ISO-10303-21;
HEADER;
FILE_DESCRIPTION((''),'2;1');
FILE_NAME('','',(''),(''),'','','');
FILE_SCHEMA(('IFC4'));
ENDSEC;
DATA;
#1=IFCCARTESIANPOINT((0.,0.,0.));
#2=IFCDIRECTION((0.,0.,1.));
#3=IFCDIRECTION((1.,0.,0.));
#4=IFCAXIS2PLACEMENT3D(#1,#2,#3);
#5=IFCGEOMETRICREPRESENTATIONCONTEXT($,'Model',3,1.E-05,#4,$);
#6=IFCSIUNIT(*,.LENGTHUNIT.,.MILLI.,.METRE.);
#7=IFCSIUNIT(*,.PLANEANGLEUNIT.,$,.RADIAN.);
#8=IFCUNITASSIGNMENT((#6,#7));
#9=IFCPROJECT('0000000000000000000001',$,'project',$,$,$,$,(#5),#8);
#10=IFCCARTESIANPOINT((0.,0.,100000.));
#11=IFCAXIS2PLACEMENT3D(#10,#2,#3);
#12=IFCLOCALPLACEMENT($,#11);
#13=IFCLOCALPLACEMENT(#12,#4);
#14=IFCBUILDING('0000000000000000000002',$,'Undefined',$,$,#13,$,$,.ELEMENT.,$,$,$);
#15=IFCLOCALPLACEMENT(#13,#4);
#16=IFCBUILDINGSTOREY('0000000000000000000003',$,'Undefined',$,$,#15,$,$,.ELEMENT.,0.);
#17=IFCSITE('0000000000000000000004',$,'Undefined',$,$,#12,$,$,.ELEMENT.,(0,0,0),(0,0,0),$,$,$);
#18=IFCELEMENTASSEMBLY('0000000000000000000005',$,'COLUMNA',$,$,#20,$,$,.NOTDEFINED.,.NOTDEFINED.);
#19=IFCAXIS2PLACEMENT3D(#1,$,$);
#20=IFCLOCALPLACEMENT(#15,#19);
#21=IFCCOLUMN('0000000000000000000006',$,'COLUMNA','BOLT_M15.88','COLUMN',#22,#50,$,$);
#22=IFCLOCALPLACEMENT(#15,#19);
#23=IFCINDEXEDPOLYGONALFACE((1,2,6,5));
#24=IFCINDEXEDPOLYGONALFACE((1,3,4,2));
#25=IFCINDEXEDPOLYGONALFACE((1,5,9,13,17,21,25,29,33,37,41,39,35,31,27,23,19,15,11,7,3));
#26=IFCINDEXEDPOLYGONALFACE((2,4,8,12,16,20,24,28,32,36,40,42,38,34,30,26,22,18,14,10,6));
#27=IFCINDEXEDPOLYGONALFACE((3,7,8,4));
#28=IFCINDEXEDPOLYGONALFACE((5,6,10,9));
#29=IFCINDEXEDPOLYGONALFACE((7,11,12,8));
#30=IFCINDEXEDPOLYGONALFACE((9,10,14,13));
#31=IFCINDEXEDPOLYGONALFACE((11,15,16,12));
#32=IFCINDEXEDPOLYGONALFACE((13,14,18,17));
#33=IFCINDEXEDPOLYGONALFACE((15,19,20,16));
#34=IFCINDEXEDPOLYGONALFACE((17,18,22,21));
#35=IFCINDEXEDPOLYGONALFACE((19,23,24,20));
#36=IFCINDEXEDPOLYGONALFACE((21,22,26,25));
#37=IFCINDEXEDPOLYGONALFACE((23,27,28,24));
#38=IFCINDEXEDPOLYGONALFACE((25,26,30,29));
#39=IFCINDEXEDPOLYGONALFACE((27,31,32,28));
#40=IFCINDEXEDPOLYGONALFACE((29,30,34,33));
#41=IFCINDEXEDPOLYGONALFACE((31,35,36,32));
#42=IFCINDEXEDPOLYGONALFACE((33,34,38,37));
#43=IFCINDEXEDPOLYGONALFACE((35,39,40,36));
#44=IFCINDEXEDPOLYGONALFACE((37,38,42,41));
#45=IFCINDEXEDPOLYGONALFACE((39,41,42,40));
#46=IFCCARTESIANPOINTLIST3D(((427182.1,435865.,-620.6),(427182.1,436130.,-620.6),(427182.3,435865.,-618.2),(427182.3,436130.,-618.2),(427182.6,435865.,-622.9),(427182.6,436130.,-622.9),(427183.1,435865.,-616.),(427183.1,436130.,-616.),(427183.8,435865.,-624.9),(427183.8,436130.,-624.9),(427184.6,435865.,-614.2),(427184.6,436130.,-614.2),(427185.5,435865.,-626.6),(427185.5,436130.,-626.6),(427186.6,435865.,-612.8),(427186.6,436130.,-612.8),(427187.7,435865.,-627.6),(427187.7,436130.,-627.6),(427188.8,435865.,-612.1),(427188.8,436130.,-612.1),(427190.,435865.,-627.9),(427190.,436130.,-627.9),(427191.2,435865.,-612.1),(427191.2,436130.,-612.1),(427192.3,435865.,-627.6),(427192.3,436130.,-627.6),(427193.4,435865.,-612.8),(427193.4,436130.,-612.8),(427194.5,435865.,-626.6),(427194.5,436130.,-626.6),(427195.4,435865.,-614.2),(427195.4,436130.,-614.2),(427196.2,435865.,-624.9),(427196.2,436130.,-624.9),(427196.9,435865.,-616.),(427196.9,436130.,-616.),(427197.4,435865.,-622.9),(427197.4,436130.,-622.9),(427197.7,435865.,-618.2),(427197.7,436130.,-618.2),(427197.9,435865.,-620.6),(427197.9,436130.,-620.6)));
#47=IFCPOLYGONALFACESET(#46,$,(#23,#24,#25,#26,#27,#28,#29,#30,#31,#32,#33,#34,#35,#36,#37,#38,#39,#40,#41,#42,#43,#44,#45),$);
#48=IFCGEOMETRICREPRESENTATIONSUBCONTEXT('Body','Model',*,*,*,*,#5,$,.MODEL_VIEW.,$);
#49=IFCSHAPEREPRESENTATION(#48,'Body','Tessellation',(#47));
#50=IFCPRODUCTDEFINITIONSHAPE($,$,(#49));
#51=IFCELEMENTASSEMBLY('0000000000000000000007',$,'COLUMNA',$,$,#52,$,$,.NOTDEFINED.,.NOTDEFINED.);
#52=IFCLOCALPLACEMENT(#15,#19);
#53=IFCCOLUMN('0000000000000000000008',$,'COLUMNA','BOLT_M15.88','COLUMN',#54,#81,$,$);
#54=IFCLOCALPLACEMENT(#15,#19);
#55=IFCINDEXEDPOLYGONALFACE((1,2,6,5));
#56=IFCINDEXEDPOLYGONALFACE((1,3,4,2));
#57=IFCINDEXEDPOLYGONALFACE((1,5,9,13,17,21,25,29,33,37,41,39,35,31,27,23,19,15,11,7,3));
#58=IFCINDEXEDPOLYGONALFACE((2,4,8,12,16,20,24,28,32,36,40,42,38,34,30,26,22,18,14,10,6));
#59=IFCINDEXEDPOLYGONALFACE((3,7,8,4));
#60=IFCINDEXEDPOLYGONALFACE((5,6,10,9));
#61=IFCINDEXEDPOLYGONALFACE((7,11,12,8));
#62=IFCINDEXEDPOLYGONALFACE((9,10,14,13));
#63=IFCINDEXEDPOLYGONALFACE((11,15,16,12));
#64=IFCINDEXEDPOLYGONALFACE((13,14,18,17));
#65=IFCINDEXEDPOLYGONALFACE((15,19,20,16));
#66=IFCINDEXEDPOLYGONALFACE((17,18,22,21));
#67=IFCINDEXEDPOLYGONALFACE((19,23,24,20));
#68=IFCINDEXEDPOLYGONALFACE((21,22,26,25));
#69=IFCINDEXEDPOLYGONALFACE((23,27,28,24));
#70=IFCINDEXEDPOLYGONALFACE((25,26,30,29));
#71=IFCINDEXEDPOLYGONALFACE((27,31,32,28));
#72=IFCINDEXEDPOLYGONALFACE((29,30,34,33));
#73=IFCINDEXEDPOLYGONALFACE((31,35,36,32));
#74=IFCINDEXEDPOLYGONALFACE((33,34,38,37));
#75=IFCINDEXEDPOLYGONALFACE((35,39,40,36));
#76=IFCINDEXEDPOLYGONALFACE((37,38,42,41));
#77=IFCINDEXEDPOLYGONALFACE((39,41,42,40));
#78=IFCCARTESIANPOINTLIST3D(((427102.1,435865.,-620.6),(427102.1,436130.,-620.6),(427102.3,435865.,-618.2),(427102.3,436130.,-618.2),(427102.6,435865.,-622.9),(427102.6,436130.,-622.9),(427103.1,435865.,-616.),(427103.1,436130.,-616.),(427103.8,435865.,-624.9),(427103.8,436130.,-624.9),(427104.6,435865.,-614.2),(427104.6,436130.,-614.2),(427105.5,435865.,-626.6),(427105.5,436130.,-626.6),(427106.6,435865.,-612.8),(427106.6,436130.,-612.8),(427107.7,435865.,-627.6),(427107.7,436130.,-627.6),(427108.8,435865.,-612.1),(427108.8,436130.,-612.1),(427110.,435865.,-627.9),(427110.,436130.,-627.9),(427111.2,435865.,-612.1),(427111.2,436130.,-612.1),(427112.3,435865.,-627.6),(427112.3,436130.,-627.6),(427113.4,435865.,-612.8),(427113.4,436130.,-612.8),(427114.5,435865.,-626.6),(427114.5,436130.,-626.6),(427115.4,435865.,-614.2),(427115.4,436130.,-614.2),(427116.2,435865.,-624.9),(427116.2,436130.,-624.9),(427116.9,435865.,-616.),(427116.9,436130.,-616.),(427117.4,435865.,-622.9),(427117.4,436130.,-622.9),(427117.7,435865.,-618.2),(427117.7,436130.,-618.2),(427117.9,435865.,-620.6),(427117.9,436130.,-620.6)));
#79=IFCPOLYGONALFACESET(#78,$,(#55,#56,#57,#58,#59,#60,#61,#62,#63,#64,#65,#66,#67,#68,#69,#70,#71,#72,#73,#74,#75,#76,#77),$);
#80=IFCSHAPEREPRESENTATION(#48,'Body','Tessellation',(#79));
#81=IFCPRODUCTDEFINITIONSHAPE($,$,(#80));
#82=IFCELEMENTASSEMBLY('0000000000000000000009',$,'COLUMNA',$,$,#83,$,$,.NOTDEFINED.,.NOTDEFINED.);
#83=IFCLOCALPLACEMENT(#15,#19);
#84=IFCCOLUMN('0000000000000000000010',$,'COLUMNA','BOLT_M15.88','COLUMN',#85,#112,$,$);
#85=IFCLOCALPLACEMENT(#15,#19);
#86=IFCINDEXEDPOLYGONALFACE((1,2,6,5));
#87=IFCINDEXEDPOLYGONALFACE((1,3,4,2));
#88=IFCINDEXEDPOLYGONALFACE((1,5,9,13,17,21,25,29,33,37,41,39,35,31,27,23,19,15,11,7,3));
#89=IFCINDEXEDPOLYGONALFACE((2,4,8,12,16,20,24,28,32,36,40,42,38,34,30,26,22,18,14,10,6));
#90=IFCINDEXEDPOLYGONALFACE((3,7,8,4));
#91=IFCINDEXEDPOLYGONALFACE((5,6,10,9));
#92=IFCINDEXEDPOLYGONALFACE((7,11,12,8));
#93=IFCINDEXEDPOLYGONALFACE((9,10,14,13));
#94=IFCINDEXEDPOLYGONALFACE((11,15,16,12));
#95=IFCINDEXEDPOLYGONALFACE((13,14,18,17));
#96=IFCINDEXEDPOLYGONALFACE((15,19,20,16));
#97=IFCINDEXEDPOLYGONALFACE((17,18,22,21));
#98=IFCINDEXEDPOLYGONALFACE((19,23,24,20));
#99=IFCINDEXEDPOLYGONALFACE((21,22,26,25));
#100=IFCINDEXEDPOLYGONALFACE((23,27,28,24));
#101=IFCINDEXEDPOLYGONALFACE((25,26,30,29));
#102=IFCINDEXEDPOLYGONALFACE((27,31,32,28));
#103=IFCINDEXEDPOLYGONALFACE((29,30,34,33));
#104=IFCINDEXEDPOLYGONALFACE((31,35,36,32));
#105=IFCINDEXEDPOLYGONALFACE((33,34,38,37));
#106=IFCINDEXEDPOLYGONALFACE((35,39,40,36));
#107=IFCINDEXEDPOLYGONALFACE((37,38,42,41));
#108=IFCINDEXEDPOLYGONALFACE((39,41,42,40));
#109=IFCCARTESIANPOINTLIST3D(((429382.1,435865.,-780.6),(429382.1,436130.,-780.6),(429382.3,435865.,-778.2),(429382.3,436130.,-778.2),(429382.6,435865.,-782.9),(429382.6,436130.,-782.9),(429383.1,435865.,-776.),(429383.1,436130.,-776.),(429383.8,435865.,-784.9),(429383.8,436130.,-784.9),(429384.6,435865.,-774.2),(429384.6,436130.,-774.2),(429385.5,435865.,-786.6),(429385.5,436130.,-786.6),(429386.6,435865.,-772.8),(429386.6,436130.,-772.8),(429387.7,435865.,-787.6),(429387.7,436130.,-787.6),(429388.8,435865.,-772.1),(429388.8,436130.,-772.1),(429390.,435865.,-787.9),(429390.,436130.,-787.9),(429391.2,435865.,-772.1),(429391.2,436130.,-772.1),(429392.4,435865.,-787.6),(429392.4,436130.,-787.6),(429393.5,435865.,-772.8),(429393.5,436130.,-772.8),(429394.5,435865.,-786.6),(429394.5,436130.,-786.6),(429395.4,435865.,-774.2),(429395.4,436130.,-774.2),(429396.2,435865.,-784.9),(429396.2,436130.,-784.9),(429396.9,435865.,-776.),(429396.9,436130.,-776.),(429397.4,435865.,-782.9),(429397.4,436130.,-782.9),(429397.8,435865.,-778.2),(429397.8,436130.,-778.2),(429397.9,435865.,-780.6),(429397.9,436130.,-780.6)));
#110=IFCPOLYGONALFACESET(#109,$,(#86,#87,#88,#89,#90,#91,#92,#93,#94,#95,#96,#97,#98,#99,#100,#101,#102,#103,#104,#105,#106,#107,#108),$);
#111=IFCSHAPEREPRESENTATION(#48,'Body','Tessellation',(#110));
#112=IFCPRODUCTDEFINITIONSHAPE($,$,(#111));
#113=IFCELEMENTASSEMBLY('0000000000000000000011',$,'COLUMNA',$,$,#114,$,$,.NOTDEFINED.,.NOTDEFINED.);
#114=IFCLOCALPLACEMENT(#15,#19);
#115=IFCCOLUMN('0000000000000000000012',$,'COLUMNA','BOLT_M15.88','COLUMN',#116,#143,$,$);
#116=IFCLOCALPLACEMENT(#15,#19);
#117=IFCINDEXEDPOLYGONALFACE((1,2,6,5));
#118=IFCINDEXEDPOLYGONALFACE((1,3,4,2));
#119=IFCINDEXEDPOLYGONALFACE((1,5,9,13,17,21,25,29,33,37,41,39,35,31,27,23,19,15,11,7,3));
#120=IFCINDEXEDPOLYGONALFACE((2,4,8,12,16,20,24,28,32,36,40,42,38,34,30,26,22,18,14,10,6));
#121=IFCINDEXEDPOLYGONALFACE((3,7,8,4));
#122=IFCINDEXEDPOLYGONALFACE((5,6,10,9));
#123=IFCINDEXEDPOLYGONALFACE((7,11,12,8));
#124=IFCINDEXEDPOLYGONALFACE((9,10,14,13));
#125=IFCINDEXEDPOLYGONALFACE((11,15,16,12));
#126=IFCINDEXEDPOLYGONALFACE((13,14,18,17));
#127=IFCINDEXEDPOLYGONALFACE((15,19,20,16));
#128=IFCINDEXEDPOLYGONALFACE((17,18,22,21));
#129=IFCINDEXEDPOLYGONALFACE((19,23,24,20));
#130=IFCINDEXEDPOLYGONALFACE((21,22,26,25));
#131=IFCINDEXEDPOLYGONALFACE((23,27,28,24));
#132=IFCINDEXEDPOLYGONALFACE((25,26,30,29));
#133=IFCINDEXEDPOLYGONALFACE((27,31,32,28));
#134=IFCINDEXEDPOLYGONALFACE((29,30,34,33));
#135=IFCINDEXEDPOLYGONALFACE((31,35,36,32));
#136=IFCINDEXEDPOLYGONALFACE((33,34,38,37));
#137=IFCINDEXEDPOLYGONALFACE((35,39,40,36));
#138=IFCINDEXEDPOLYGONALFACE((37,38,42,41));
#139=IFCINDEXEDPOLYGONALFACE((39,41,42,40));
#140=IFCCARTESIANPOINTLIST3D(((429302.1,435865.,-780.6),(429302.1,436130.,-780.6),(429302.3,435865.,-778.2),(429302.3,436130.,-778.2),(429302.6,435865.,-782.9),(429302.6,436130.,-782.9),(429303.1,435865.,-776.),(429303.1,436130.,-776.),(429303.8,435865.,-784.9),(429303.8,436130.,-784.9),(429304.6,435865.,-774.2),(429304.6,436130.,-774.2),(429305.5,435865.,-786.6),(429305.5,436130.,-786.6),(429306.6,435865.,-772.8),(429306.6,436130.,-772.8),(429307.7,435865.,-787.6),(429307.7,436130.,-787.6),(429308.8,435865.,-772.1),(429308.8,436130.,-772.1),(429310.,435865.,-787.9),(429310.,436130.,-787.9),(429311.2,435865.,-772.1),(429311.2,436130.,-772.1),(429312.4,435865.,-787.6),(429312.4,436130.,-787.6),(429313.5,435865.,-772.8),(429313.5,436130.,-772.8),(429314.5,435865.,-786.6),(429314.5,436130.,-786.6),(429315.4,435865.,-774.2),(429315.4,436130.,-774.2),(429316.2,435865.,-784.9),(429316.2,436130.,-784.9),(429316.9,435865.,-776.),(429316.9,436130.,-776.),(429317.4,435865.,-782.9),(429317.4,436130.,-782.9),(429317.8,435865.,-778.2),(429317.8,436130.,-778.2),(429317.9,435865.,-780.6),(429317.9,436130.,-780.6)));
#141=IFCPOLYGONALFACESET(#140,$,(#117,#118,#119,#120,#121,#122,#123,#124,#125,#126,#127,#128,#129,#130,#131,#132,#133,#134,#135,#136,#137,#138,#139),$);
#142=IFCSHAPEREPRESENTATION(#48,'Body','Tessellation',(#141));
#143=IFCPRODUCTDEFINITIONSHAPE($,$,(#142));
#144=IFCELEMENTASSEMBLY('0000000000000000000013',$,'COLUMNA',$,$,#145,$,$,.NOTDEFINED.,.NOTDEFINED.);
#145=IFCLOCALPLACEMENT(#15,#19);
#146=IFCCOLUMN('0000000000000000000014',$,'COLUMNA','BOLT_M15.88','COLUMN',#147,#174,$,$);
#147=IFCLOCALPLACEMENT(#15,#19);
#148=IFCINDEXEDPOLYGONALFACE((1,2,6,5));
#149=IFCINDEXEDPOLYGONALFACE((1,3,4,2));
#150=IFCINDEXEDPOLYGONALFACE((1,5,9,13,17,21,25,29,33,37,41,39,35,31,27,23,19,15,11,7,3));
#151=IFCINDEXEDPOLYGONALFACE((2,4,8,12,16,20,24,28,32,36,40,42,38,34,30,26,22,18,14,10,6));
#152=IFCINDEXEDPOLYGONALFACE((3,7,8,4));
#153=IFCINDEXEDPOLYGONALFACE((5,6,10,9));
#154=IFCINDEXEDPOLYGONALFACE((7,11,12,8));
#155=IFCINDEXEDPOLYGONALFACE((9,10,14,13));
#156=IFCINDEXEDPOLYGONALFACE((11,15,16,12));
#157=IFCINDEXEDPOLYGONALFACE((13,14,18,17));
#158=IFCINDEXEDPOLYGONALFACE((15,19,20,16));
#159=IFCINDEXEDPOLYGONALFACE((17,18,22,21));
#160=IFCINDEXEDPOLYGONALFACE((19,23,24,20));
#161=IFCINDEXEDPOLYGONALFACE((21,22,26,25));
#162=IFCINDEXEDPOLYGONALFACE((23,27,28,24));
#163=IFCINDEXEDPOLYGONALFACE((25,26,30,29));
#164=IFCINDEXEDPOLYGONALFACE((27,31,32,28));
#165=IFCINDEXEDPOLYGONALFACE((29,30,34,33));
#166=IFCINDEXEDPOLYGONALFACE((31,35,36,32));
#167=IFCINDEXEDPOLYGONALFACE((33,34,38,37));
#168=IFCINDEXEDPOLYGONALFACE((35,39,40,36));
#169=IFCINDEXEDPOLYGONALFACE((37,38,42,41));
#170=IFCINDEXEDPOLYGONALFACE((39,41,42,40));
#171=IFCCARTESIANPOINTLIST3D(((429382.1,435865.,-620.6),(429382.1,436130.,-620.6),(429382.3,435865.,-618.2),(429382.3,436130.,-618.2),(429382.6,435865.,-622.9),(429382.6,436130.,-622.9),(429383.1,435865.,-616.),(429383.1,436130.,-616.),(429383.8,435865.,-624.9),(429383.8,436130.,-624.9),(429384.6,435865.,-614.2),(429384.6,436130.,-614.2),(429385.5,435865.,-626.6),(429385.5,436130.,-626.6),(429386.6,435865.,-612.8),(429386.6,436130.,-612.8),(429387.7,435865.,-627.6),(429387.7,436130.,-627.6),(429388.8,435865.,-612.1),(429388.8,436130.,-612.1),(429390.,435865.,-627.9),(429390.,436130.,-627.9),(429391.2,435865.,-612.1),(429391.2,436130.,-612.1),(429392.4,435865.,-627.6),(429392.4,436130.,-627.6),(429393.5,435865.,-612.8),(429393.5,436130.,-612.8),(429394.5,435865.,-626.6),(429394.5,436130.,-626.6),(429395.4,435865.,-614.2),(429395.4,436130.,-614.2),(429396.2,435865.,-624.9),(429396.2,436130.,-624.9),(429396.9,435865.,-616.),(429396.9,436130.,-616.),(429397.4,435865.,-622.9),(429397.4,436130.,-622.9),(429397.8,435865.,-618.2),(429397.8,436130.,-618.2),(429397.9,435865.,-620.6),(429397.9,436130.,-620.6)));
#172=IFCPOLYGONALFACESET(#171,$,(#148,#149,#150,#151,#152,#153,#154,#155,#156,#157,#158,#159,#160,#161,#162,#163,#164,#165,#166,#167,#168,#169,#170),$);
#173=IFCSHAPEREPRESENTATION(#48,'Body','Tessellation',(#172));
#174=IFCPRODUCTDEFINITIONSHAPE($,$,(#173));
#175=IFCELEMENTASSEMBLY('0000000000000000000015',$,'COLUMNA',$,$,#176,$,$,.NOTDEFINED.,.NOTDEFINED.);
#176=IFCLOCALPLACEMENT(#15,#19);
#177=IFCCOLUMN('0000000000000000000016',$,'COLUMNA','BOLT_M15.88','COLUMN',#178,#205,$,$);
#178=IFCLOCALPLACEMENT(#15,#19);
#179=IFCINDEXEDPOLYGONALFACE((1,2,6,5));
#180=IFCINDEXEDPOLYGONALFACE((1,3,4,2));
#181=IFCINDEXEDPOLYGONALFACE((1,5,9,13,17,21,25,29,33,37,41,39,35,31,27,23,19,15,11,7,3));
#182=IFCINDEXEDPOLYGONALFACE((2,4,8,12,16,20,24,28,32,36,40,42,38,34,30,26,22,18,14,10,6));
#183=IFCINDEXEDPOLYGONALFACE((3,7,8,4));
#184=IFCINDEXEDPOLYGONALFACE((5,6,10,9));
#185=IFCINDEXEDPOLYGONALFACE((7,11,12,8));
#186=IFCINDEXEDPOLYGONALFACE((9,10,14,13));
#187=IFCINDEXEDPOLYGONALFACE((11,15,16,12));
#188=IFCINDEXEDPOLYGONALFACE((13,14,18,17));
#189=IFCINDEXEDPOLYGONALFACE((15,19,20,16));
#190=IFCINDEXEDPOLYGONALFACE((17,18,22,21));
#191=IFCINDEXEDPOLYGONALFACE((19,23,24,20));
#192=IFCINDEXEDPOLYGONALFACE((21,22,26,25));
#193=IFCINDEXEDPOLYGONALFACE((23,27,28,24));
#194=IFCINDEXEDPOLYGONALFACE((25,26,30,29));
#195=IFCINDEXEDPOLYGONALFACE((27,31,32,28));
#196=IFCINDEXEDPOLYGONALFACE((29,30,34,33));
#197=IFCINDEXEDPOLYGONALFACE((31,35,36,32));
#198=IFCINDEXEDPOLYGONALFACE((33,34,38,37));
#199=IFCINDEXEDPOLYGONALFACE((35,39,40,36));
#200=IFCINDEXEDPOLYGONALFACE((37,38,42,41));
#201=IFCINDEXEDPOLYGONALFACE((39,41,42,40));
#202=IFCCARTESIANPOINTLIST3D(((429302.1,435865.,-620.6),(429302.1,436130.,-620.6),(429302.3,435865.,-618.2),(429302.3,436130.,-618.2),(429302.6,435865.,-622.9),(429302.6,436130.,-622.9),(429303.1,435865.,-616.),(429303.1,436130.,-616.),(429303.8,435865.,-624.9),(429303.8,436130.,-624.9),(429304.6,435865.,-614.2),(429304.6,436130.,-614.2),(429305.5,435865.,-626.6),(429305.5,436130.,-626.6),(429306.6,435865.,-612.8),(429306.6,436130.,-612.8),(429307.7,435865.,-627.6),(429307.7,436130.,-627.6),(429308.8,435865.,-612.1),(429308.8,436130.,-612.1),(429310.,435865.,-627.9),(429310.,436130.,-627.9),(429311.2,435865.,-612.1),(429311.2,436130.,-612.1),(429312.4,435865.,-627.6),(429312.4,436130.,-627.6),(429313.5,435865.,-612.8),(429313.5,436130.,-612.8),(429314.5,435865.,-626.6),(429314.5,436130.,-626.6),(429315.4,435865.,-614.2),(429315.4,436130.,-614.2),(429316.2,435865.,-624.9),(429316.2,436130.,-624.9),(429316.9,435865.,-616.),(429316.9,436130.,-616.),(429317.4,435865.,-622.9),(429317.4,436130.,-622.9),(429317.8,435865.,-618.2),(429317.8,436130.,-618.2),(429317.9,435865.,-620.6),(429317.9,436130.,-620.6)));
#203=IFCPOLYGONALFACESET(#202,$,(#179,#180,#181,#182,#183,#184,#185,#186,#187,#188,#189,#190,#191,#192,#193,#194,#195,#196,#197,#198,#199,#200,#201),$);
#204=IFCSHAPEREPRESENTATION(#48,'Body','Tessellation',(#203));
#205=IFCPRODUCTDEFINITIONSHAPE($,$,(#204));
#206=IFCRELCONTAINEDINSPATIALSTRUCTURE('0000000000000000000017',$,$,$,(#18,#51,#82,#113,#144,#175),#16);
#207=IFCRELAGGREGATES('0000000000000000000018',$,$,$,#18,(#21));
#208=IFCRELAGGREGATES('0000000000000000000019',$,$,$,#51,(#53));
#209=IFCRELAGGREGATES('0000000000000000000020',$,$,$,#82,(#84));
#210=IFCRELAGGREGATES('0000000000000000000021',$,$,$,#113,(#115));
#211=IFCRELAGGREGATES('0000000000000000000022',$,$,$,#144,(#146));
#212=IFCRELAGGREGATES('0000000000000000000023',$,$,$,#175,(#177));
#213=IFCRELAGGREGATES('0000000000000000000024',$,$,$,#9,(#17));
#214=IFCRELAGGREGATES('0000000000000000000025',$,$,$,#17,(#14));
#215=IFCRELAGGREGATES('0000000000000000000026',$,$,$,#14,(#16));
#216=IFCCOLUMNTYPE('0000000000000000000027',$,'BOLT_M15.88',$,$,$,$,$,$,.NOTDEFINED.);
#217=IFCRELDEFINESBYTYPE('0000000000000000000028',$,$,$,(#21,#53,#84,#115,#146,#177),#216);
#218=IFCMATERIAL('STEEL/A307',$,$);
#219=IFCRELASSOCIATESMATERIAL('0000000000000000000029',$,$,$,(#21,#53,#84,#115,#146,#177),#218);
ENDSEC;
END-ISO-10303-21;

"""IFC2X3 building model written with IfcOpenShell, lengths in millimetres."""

from ifc_helpers import new_model, si_unit, frame, origin_with_axes, origin_2d_with_axis, place, context, subcontext, project, spatial, circle, extrude, material, type_object, element, aggregate, save


model = new_model("IFC2X3")

# Units and contexts
model_context = context("Model", 3, precision=1e-05, world=origin_with_axes())
body_context = subcontext(model_context, "Body", "Model", "MODEL_VIEW")
ifc_project = project(units=[si_unit("LENGTHUNIT", "METRE", prefix="MILLI"), si_unit("PLANEANGLEUNIT", "RADIAN")], contexts=[model_context])

# Site, building, storey
site_placement = place(None, frame((0.0, 0.0, 100000.0), z_axis=(0.0, 0.0, 1.0), x_axis=(1.0, 0.0, 0.0)))
site = spatial("IfcSite", under=ifc_project, at=site_placement, Name="Undefined", CompositionType="ELEMENT", RefLatitude=(0, 0, 0), RefLongitude=(0, 0, 0))
building_placement = place(site_placement, origin_with_axes())
building = spatial("IfcBuilding", under=site, at=building_placement, Name="Undefined", CompositionType="ELEMENT")
storey_placement = place(building_placement, origin_with_axes())
storey = spatial("IfcBuildingStorey", under=building, at=storey_placement, Name="Undefined", CompositionType="ELEMENT", Elevation=0.0)

# Element assemblies, columns
ifc_material_1 = material(Name="STEEL/A307")
column_type_1 = type_object("IfcColumnType", Name="BOLT_M15.88", PredefinedType="NOTDEFINED")
assembly_1_placement = place(storey_placement, origin_with_axes())
assembly_1 = element("IfcElementAssembly", 1, at=assembly_1_placement, inside=storey, Name="COLUMNA", AssemblyPlace="NOTDEFINED", PredefinedType="NOTDEFINED")
column_1_placement = place(assembly_1_placement, frame((427190.0, 436130.0, -620.0), z_axis=(0.0, -1.0, -0.000003), x_axis=(-1.0, 0.0, 0.0)))
column_1 = element("IfcColumn", 2, at=column_1_placement, type_object=column_type_1, material=ifc_material_1, Name="COLUMNA", Description="BOLT_M15.88", ObjectType="COLUMN", context=body_context, shape_type="SweptSolid", body=[
    extrude(circle(Radius=7.9, at=origin_2d_with_axis()), frame((0.0, 0.0, 265.0), z_axis=(0.0, 0.0, -1.0), x_axis=(0.0, 1.0, 0.0)), (0.0, 0.0, 1.0), 265.0),
])
aggregate(assembly_1, [column_1])
assembly_2_placement = place(storey_placement, origin_with_axes())
assembly_2 = element("IfcElementAssembly", 3, at=assembly_2_placement, inside=storey, Name="COLUMNA", AssemblyPlace="NOTDEFINED", PredefinedType="NOTDEFINED")
column_2_placement = place(assembly_2_placement, frame((427110.0, 436130.0, -620.0), z_axis=(0.0, -1.0, -0.000003), x_axis=(-1.0, 0.0, 0.0)))
column_2 = element("IfcColumn", 4, at=column_2_placement, type_object=column_type_1, material=ifc_material_1, Name="COLUMNA", Description="BOLT_M15.88", ObjectType="COLUMN", context=body_context, shape_type="SweptSolid", body=[
    extrude(circle(Radius=7.9, at=origin_2d_with_axis()), frame((0.0, 0.0, 265.0), z_axis=(0.0, 0.0, -1.0), x_axis=(0.0, 1.0, 0.0)), (0.0, 0.0, 1.0), 265.0),
])
aggregate(assembly_2, [column_2])
assembly_3_placement = place(storey_placement, origin_with_axes())
assembly_3 = element("IfcElementAssembly", 5, at=assembly_3_placement, inside=storey, Name="COLUMNA", AssemblyPlace="NOTDEFINED", PredefinedType="NOTDEFINED")
column_3_placement = place(assembly_3_placement, frame((429390.0, 436130.0, -780.0), z_axis=(0.0, -1.0, -0.000003), x_axis=(-1.0, 0.0, 0.0)))
column_3 = element("IfcColumn", 6, at=column_3_placement, type_object=column_type_1, material=ifc_material_1, Name="COLUMNA", Description="BOLT_M15.88", ObjectType="COLUMN", context=body_context, shape_type="SweptSolid", body=[
    extrude(circle(Radius=7.9, at=origin_2d_with_axis()), frame((0.0, 0.0, 265.0), z_axis=(0.0, 0.0, -1.0), x_axis=(0.0, 1.0, 0.0)), (0.0, 0.0, 1.0), 265.0),
])
aggregate(assembly_3, [column_3])
assembly_4_placement = place(storey_placement, origin_with_axes())
assembly_4 = element("IfcElementAssembly", 7, at=assembly_4_placement, inside=storey, Name="COLUMNA", AssemblyPlace="NOTDEFINED", PredefinedType="NOTDEFINED")
column_4_placement = place(assembly_4_placement, frame((429310.0, 436130.0, -780.0), z_axis=(0.0, -1.0, -0.000003), x_axis=(-1.0, 0.0, 0.0)))
column_4 = element("IfcColumn", 8, at=column_4_placement, type_object=column_type_1, material=ifc_material_1, Name="COLUMNA", Description="BOLT_M15.88", ObjectType="COLUMN", context=body_context, shape_type="SweptSolid", body=[
    extrude(circle(Radius=7.9, at=origin_2d_with_axis()), frame((0.0, 0.0, 265.0), z_axis=(0.0, 0.0, -1.0), x_axis=(0.0, 1.0, 0.0)), (0.0, 0.0, 1.0), 265.0),
])
aggregate(assembly_4, [column_4])
assembly_5_placement = place(storey_placement, origin_with_axes())
assembly_5 = element("IfcElementAssembly", 9, at=assembly_5_placement, inside=storey, Name="COLUMNA", AssemblyPlace="NOTDEFINED", PredefinedType="NOTDEFINED")
column_5_placement = place(assembly_5_placement, frame((429390.0, 436130.0, -620.0), z_axis=(0.0, -1.0, -0.000003), x_axis=(-1.0, 0.0, 0.0)))
column_5 = element("IfcColumn", 10, at=column_5_placement, type_object=column_type_1, material=ifc_material_1, Name="COLUMNA", Description="BOLT_M15.88", ObjectType="COLUMN", context=body_context, shape_type="SweptSolid", body=[
    extrude(circle(Radius=7.9, at=origin_2d_with_axis()), frame((0.0, 0.0, 265.0), z_axis=(0.0, 0.0, -1.0), x_axis=(0.0, 1.0, 0.0)), (0.0, 0.0, 1.0), 265.0),
])
aggregate(assembly_5, [column_5])
assembly_6_placement = place(storey_placement, origin_with_axes())
assembly_6 = element("IfcElementAssembly", 11, at=assembly_6_placement, inside=storey, Name="COLUMNA", AssemblyPlace="NOTDEFINED", PredefinedType="NOTDEFINED")
column_6_placement = place(assembly_6_placement, frame((429310.0, 436130.0, -620.0), z_axis=(0.0, -1.0, -0.000003), x_axis=(-1.0, 0.0, 0.0)))
column_6 = element("IfcColumn", 12, at=column_6_placement, type_object=column_type_1, material=ifc_material_1, Name="COLUMNA", Description="BOLT_M15.88", ObjectType="COLUMN", context=body_context, shape_type="SweptSolid", body=[
    extrude(circle(Radius=7.9, at=origin_2d_with_axis()), frame((0.0, 0.0, 265.0), z_axis=(0.0, 0.0, -1.0), x_axis=(0.0, 1.0, 0.0)), (0.0, 0.0, 1.0), 265.0),
])
aggregate(assembly_6, [column_6])

save(model, "model.ifc")
